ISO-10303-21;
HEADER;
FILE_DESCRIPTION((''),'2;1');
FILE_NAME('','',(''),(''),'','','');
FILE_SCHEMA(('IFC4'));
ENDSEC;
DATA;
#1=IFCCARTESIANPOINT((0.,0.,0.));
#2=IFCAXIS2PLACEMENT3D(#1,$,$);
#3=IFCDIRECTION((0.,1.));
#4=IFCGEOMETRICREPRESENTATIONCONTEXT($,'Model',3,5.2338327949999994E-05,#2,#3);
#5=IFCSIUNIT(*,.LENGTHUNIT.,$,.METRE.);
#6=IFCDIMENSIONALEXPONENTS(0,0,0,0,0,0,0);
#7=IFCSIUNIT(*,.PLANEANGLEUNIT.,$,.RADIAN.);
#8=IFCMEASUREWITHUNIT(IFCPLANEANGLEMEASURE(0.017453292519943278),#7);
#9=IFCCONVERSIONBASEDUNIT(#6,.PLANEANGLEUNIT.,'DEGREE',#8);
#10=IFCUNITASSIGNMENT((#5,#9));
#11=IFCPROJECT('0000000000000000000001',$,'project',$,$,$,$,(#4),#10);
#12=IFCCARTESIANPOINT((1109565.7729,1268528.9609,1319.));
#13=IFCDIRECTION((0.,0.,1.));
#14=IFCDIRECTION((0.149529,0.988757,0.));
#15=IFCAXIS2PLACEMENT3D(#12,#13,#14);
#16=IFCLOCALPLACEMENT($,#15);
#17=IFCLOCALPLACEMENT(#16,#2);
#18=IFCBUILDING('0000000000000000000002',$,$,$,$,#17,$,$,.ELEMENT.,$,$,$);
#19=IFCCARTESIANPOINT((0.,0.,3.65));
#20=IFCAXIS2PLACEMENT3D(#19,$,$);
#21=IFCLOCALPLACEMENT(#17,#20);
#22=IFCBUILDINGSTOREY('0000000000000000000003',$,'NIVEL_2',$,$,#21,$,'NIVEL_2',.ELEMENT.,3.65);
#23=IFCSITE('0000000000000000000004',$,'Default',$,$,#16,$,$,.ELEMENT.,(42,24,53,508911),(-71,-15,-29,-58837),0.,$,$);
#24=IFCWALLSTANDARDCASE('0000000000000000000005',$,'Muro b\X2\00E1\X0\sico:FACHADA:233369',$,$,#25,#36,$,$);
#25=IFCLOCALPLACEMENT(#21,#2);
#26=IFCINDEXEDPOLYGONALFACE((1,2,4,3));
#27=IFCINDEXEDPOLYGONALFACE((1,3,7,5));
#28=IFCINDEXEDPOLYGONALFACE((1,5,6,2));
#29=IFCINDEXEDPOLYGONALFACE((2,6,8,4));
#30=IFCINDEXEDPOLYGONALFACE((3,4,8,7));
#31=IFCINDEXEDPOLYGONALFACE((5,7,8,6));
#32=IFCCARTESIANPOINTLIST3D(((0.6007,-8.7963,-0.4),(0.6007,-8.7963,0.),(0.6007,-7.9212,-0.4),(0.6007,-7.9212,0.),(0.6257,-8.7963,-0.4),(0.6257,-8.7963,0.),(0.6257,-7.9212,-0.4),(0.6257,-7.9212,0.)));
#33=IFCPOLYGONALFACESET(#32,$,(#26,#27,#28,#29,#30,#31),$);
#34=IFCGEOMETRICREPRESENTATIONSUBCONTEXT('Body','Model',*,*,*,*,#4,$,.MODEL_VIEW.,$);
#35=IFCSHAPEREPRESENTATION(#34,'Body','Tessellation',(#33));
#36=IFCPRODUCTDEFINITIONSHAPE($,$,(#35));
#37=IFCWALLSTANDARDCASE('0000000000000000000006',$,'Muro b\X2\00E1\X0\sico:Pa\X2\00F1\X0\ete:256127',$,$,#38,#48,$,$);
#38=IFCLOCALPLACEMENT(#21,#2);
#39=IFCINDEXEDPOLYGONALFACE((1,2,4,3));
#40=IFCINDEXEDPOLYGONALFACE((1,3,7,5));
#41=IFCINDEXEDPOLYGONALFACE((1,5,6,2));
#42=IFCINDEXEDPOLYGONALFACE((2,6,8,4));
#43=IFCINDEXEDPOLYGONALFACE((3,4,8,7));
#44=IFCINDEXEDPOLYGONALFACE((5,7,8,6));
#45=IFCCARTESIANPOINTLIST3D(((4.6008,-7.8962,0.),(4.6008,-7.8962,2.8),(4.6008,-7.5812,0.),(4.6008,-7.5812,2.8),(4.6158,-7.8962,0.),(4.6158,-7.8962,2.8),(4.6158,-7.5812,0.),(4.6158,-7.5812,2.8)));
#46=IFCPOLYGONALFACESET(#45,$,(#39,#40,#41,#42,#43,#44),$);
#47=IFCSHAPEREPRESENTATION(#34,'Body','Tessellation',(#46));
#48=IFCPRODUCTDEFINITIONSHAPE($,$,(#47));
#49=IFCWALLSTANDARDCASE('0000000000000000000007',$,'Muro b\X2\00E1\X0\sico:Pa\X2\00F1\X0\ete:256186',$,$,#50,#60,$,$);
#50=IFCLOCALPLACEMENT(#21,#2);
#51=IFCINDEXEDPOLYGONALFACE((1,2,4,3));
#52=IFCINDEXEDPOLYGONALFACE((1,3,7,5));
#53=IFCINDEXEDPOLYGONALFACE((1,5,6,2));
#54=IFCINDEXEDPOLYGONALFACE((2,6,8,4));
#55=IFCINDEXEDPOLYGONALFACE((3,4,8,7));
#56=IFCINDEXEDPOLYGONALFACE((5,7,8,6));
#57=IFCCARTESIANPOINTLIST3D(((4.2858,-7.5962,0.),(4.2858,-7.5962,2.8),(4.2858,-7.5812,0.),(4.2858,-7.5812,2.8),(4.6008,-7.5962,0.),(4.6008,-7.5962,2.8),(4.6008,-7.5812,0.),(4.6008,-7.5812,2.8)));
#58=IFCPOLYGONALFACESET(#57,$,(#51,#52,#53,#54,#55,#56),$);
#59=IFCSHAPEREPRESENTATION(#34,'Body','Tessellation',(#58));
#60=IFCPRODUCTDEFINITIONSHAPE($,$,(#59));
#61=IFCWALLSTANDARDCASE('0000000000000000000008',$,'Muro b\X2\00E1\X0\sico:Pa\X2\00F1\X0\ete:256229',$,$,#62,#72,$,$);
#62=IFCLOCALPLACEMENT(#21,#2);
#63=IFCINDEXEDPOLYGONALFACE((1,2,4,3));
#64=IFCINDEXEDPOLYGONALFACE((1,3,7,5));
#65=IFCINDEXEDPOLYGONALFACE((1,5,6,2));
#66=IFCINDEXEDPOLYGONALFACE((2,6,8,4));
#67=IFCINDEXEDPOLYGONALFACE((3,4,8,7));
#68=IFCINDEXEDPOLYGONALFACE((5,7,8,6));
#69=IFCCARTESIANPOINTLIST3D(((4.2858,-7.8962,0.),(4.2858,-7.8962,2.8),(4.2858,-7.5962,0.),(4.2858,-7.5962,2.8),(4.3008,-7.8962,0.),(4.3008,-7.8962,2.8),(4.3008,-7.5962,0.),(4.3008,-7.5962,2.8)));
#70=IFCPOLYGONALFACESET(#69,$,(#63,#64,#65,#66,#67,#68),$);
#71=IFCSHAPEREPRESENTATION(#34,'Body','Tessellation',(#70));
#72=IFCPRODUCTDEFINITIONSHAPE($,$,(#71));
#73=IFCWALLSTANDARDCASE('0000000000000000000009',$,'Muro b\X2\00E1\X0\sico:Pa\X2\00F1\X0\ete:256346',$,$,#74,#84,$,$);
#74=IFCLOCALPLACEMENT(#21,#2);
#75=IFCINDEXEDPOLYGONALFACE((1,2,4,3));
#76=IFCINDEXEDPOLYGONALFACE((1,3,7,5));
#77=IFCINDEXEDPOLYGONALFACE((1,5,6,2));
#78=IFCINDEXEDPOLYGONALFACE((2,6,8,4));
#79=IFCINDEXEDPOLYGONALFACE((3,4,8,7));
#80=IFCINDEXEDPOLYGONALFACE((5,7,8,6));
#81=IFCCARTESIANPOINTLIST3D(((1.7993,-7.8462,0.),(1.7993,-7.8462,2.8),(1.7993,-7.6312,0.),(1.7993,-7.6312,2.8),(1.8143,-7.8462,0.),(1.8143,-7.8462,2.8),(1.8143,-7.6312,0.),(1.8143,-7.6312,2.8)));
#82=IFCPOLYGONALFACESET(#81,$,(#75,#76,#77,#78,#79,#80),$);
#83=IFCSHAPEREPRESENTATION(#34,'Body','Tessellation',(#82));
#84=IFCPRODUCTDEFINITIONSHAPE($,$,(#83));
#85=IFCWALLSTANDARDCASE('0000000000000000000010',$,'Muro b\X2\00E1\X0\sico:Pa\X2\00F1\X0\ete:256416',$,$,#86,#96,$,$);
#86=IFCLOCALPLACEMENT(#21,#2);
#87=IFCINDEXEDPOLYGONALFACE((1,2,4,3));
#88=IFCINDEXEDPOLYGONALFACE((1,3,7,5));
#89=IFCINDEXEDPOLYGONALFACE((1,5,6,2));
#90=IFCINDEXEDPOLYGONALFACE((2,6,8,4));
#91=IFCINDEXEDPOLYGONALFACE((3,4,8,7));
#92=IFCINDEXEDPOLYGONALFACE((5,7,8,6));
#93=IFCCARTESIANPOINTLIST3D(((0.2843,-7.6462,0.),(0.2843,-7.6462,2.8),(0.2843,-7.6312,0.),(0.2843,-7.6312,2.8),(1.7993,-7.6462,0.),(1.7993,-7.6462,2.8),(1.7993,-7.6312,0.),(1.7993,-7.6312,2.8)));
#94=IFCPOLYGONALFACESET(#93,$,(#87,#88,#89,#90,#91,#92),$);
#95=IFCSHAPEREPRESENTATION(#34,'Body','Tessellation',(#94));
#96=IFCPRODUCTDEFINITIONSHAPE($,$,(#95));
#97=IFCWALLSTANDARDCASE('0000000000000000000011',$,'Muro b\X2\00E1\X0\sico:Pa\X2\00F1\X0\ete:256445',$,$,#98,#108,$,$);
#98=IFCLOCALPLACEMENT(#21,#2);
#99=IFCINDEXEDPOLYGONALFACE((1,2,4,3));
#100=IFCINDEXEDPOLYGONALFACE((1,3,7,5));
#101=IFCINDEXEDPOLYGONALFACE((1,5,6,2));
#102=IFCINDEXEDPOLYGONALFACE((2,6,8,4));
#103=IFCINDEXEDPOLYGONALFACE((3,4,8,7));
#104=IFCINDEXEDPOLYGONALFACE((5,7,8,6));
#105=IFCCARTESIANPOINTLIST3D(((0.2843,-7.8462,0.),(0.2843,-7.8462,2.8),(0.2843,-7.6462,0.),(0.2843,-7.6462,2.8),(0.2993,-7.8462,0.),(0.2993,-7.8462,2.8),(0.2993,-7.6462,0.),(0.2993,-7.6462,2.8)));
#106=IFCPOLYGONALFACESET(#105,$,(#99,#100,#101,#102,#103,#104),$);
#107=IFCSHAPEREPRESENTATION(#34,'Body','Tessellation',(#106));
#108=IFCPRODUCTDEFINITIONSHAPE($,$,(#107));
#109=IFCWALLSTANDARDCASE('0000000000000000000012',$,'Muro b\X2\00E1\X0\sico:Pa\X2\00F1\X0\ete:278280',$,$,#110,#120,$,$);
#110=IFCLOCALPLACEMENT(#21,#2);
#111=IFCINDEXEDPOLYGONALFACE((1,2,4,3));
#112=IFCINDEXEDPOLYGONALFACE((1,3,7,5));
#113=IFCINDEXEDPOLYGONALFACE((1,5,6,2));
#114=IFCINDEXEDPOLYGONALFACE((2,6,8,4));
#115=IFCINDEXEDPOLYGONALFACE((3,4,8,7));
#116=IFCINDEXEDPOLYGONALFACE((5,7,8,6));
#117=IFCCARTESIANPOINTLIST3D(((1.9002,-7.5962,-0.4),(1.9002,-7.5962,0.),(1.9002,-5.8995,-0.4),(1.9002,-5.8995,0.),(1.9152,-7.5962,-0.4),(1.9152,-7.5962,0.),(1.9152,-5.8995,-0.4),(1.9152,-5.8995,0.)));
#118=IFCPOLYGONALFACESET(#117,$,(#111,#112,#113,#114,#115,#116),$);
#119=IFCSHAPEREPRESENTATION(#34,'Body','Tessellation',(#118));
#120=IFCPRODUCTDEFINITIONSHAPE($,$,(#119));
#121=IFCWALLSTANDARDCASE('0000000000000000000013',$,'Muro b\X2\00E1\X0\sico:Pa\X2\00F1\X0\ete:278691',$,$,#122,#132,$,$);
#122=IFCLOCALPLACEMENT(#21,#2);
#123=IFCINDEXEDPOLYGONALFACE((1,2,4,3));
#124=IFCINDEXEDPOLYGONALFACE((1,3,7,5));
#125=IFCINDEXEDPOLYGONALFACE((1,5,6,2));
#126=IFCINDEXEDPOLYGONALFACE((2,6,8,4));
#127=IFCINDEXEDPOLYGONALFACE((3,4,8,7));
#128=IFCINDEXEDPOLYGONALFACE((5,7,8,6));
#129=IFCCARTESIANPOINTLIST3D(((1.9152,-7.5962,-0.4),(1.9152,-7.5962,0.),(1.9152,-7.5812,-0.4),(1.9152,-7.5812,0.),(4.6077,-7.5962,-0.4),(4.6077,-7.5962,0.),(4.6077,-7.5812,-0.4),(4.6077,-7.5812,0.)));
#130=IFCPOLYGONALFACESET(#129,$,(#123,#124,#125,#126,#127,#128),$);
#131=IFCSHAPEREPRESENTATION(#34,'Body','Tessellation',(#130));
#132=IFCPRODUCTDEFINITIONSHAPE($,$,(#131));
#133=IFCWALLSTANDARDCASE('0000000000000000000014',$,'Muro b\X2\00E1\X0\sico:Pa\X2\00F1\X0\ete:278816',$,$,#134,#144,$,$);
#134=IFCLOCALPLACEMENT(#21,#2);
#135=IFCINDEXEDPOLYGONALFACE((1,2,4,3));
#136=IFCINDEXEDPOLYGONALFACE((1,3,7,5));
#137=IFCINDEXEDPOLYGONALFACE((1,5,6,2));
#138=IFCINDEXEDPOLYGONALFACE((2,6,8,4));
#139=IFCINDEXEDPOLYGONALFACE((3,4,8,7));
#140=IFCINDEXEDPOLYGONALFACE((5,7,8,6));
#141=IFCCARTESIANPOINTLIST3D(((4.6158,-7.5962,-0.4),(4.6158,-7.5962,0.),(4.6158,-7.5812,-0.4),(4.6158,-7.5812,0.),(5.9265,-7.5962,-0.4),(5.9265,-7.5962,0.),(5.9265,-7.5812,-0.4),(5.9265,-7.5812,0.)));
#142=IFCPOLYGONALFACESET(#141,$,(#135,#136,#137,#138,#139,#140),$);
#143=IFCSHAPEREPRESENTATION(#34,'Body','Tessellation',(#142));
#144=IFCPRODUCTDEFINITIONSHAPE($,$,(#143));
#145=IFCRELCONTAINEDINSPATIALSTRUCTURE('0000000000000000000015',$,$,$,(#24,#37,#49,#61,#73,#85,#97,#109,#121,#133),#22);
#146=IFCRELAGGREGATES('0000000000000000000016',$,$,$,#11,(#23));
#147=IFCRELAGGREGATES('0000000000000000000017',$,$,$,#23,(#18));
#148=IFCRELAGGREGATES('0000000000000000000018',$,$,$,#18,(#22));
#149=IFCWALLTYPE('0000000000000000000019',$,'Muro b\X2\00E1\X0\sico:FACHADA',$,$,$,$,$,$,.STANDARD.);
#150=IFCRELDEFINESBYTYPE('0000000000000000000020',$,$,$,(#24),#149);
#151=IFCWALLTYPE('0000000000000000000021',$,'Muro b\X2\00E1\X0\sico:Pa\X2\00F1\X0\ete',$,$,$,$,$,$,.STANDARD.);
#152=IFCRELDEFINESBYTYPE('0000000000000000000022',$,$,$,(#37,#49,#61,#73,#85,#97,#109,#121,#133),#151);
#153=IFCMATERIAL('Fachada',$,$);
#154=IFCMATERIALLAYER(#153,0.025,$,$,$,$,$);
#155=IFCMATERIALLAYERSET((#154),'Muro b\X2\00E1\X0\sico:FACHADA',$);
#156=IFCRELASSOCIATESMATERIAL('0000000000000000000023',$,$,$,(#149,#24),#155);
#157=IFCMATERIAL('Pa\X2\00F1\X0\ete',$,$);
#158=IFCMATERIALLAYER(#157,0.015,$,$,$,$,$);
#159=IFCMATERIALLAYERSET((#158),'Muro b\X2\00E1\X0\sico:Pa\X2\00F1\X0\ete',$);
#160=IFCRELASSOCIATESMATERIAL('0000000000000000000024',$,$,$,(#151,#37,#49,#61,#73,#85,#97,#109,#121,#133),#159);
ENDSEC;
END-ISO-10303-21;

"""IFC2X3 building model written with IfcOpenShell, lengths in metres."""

from ifc_helpers import new_model, entity, si_unit, converted_unit, direction, frame, frame_2d, origin, place, context, subcontext, project, spatial, rectangle, extrude, material, layer, layer_set, layer_usage, type_object, element, save


model = new_model("IFC2X3")

# Units and contexts
model_context = context("Model", 3, precision=5.2338327949999994e-05, world=origin(), true_north=direction((0.0, 1.0)))
body_context = subcontext(model_context, "Body", "Model", "MODEL_VIEW")
ifc_project = project(units=[si_unit("LENGTHUNIT", "METRE"), converted_unit("PLANEANGLEUNIT", "DEGREE", entity("IfcPlaneAngleMeasure", 0.017453292519943278), si_unit("PLANEANGLEUNIT", "RADIAN"), dimensions=[0, 0, 0, 0, 0, 0, 0])], contexts=[model_context])

# Site, building, storey
site_placement = place(None, frame((1109565.7729, 1268528.9609, 1319.0), z_axis=(0.0, 0.0, 1.0), x_axis=(0.149529, 0.988757, 0.0)))
site = spatial("IfcSite", under=ifc_project, at=site_placement, Name="Default", CompositionType="ELEMENT", RefLatitude=(42, 24, 53, 508911), RefLongitude=(-71, -15, -29, -58837), RefElevation=0.0)
building_placement = place(site_placement, origin())
building = spatial("IfcBuilding", under=site, at=building_placement, CompositionType="ELEMENT")
storey_placement = place(building_placement, frame((0.0, 0.0, 3.65)))
storey = spatial("IfcBuildingStorey", under=building, at=storey_placement, Name="NIVEL_2", LongName="NIVEL_2", CompositionType="ELEMENT", Elevation=3.65)

# Shared definitions
ifc_material_1 = material(Name="Pañete")

# Walls
ifc_material_2 = material(Name="Fachada")
ifc_layer_1 = layer(ifc_material_2, 0.025)
ifc_layer_set_1 = layer_set([ifc_layer_1], Name="Muro básico:FACHADA")
wall_type_1 = type_object("IfcWallType", Name="Muro básico:FACHADA", PredefinedType="STANDARD", material=ifc_layer_set_1)
ifc_layer_usage_1 = layer_usage(ifc_layer_set_1, "AXIS2", "NEGATIVE", 0.0125)
wall_1_placement = place(storey_placement, frame((0.6132, -8.7963, -0.4), z_axis=(0.0, 0.0, 1.0), x_axis=(0.0, 1.0, 0.0)))
element("IfcWallStandardCase", 1, at=wall_1_placement, inside=storey, type_object=wall_type_1, material=ifc_layer_usage_1, Name="Muro básico:FACHADA:233369", context=body_context, shape_type="SweptSolid", body=[
    extrude(rectangle(XDim=0.8751, YDim=0.025, at=frame_2d((0.4376, 0.0), x_axis=(-1.0, 0.0))), origin(), (0.0, 0.0, 1.0), 0.4),
])
ifc_layer_2 = layer(ifc_material_1, 0.015)
ifc_layer_set_2 = layer_set([ifc_layer_2], Name="Muro básico:Pañete")
ifc_layer_usage_2 = layer_usage(ifc_layer_set_2, "AXIS2", "POSITIVE", -0.0075)
wall_type_2 = type_object("IfcWallType", Name="Muro básico:Pañete", PredefinedType="STANDARD", material=ifc_layer_set_2)
wall_2_placement = place(storey_placement, frame((4.6083, -7.8962, 0.0), z_axis=(0.0, 0.0, 1.0), x_axis=(0.0, 1.0, 0.0)))
element("IfcWallStandardCase", 2, at=wall_2_placement, inside=storey, type_object=wall_type_2, material=ifc_layer_usage_2, Name="Muro básico:Pañete:256127", context=body_context, shape_type="SweptSolid", body=[
    extrude(rectangle(XDim=0.315, YDim=0.015, at=frame_2d((0.1575, 0.0), x_axis=(-1.0, 0.0))), origin(), (0.0, 0.0, 1.0), 2.8),
])
ifc_layer_usage_3 = layer_usage(ifc_layer_set_2, "AXIS2", "POSITIVE", -0.0075)
wall_3_placement = place(storey_placement, frame((4.6008, -7.5887, 0.0), z_axis=(0.0, 0.0, 1.0), x_axis=(-1.0, 0.0, 0.0)))
element("IfcWallStandardCase", 3, at=wall_3_placement, inside=storey, type_object=wall_type_2, material=ifc_layer_usage_3, Name="Muro básico:Pañete:256186", context=body_context, shape_type="SweptSolid", body=[
    extrude(rectangle(XDim=0.315, YDim=0.015, at=frame_2d((0.1575, 0.0), x_axis=(-1.0, 0.0))), origin(), (0.0, 0.0, 1.0), 2.8),
])
ifc_layer_usage_4 = layer_usage(ifc_layer_set_2, "AXIS2", "POSITIVE", -0.0075)
wall_4_placement = place(storey_placement, frame((4.2933, -7.5962, 0.0), z_axis=(0.0, 0.0, 1.0), x_axis=(0.0, -1.0, 0.0)))
element("IfcWallStandardCase", 4, at=wall_4_placement, inside=storey, type_object=wall_type_2, material=ifc_layer_usage_4, Name="Muro básico:Pañete:256229", context=body_context, shape_type="SweptSolid", body=[
    extrude(rectangle(XDim=0.3, YDim=0.015, at=frame_2d((0.15, 0.0), x_axis=(-1.0, 0.0))), origin(), (0.0, 0.0, 1.0), 2.8),
])
ifc_layer_usage_5 = layer_usage(ifc_layer_set_2, "AXIS2", "POSITIVE", -0.0075)
wall_5_placement = place(storey_placement, frame((1.8068, -7.8462, 0.0), z_axis=(0.0, 0.0, 1.0), x_axis=(0.0, 1.0, 0.0)))
element("IfcWallStandardCase", 5, at=wall_5_placement, inside=storey, type_object=wall_type_2, material=ifc_layer_usage_5, Name="Muro básico:Pañete:256346", context=body_context, shape_type="SweptSolid", body=[
    extrude(rectangle(XDim=0.215, YDim=0.015, at=frame_2d((0.1075, 0.0), x_axis=(-1.0, 0.0))), origin(), (0.0, 0.0, 1.0), 2.8),
])
ifc_layer_usage_6 = layer_usage(ifc_layer_set_2, "AXIS2", "POSITIVE", -0.0075)
wall_6_placement = place(storey_placement, frame((1.7993, -7.6387, 0.0), z_axis=(0.0, 0.0, 1.0), x_axis=(-1.0, 0.0, 0.0)))
element("IfcWallStandardCase", 6, at=wall_6_placement, inside=storey, type_object=wall_type_2, material=ifc_layer_usage_6, Name="Muro básico:Pañete:256416", context=body_context, shape_type="SweptSolid", body=[
    extrude(rectangle(XDim=1.515, YDim=0.015, at=frame_2d((0.7575, 0.0), x_axis=(-1.0, 0.0))), origin(), (0.0, 0.0, 1.0), 2.8),
])
ifc_layer_usage_7 = layer_usage(ifc_layer_set_2, "AXIS2", "POSITIVE", -0.0075)
wall_7_placement = place(storey_placement, frame((0.2918, -7.6462, 0.0), z_axis=(0.0, 0.0, 1.0), x_axis=(0.0, -1.0, 0.0)))
element("IfcWallStandardCase", 7, at=wall_7_placement, inside=storey, type_object=wall_type_2, material=ifc_layer_usage_7, Name="Muro básico:Pañete:256445", context=body_context, shape_type="SweptSolid", body=[
    extrude(rectangle(XDim=0.2, YDim=0.015, at=frame_2d((0.1, 0.0), x_axis=(-1.0, 0.0))), origin(), (0.0, 0.0, 1.0), 2.8),
])
ifc_layer_usage_8 = layer_usage(ifc_layer_set_2, "AXIS2", "NEGATIVE", 0.0075)
wall_8_placement = place(storey_placement, frame((1.9077, -5.8995, -0.4), z_axis=(0.0, 0.0, 1.0), x_axis=(0.0, -1.0, 0.0)))
element("IfcWallStandardCase", 8, at=wall_8_placement, inside=storey, type_object=wall_type_2, material=ifc_layer_usage_8, Name="Muro básico:Pañete:278280", context=body_context, shape_type="SweptSolid", body=[
    extrude(rectangle(XDim=1.6967, YDim=0.015, at=frame_2d((0.8483, 0.0), x_axis=(-1.0, 0.0))), origin(), (0.0, 0.0, 1.0), 0.4),
])
ifc_layer_usage_9 = layer_usage(ifc_layer_set_2, "AXIS2", "NEGATIVE", 0.0075)
wall_9_placement = place(storey_placement, frame((1.9152, -7.5887, -0.4)))
element("IfcWallStandardCase", 9, at=wall_9_placement, inside=storey, type_object=wall_type_2, material=ifc_layer_usage_9, Name="Muro básico:Pañete:278691", context=body_context, shape_type="SweptSolid", body=[
    extrude(rectangle(XDim=2.6925, YDim=0.015, at=frame_2d((1.3463, 0.0), x_axis=(-1.0, 0.0))), origin(), (0.0, 0.0, 1.0), 0.4),
])
ifc_layer_usage_10 = layer_usage(ifc_layer_set_2, "AXIS2", "NEGATIVE", 0.0075)
wall_10_placement = place(storey_placement, frame((4.6158, -7.5887, -0.4)))
element("IfcWallStandardCase", 10, at=wall_10_placement, inside=storey, type_object=wall_type_2, material=ifc_layer_usage_10, Name="Muro básico:Pañete:278816", context=body_context, shape_type="SweptSolid", body=[
    extrude(rectangle(XDim=1.3107, YDim=0.015, at=frame_2d((0.6554, 0.0), x_axis=(-1.0, 0.0))), origin(), (0.0, 0.0, 1.0), 0.4),
])

save(model, "model.ifc")
